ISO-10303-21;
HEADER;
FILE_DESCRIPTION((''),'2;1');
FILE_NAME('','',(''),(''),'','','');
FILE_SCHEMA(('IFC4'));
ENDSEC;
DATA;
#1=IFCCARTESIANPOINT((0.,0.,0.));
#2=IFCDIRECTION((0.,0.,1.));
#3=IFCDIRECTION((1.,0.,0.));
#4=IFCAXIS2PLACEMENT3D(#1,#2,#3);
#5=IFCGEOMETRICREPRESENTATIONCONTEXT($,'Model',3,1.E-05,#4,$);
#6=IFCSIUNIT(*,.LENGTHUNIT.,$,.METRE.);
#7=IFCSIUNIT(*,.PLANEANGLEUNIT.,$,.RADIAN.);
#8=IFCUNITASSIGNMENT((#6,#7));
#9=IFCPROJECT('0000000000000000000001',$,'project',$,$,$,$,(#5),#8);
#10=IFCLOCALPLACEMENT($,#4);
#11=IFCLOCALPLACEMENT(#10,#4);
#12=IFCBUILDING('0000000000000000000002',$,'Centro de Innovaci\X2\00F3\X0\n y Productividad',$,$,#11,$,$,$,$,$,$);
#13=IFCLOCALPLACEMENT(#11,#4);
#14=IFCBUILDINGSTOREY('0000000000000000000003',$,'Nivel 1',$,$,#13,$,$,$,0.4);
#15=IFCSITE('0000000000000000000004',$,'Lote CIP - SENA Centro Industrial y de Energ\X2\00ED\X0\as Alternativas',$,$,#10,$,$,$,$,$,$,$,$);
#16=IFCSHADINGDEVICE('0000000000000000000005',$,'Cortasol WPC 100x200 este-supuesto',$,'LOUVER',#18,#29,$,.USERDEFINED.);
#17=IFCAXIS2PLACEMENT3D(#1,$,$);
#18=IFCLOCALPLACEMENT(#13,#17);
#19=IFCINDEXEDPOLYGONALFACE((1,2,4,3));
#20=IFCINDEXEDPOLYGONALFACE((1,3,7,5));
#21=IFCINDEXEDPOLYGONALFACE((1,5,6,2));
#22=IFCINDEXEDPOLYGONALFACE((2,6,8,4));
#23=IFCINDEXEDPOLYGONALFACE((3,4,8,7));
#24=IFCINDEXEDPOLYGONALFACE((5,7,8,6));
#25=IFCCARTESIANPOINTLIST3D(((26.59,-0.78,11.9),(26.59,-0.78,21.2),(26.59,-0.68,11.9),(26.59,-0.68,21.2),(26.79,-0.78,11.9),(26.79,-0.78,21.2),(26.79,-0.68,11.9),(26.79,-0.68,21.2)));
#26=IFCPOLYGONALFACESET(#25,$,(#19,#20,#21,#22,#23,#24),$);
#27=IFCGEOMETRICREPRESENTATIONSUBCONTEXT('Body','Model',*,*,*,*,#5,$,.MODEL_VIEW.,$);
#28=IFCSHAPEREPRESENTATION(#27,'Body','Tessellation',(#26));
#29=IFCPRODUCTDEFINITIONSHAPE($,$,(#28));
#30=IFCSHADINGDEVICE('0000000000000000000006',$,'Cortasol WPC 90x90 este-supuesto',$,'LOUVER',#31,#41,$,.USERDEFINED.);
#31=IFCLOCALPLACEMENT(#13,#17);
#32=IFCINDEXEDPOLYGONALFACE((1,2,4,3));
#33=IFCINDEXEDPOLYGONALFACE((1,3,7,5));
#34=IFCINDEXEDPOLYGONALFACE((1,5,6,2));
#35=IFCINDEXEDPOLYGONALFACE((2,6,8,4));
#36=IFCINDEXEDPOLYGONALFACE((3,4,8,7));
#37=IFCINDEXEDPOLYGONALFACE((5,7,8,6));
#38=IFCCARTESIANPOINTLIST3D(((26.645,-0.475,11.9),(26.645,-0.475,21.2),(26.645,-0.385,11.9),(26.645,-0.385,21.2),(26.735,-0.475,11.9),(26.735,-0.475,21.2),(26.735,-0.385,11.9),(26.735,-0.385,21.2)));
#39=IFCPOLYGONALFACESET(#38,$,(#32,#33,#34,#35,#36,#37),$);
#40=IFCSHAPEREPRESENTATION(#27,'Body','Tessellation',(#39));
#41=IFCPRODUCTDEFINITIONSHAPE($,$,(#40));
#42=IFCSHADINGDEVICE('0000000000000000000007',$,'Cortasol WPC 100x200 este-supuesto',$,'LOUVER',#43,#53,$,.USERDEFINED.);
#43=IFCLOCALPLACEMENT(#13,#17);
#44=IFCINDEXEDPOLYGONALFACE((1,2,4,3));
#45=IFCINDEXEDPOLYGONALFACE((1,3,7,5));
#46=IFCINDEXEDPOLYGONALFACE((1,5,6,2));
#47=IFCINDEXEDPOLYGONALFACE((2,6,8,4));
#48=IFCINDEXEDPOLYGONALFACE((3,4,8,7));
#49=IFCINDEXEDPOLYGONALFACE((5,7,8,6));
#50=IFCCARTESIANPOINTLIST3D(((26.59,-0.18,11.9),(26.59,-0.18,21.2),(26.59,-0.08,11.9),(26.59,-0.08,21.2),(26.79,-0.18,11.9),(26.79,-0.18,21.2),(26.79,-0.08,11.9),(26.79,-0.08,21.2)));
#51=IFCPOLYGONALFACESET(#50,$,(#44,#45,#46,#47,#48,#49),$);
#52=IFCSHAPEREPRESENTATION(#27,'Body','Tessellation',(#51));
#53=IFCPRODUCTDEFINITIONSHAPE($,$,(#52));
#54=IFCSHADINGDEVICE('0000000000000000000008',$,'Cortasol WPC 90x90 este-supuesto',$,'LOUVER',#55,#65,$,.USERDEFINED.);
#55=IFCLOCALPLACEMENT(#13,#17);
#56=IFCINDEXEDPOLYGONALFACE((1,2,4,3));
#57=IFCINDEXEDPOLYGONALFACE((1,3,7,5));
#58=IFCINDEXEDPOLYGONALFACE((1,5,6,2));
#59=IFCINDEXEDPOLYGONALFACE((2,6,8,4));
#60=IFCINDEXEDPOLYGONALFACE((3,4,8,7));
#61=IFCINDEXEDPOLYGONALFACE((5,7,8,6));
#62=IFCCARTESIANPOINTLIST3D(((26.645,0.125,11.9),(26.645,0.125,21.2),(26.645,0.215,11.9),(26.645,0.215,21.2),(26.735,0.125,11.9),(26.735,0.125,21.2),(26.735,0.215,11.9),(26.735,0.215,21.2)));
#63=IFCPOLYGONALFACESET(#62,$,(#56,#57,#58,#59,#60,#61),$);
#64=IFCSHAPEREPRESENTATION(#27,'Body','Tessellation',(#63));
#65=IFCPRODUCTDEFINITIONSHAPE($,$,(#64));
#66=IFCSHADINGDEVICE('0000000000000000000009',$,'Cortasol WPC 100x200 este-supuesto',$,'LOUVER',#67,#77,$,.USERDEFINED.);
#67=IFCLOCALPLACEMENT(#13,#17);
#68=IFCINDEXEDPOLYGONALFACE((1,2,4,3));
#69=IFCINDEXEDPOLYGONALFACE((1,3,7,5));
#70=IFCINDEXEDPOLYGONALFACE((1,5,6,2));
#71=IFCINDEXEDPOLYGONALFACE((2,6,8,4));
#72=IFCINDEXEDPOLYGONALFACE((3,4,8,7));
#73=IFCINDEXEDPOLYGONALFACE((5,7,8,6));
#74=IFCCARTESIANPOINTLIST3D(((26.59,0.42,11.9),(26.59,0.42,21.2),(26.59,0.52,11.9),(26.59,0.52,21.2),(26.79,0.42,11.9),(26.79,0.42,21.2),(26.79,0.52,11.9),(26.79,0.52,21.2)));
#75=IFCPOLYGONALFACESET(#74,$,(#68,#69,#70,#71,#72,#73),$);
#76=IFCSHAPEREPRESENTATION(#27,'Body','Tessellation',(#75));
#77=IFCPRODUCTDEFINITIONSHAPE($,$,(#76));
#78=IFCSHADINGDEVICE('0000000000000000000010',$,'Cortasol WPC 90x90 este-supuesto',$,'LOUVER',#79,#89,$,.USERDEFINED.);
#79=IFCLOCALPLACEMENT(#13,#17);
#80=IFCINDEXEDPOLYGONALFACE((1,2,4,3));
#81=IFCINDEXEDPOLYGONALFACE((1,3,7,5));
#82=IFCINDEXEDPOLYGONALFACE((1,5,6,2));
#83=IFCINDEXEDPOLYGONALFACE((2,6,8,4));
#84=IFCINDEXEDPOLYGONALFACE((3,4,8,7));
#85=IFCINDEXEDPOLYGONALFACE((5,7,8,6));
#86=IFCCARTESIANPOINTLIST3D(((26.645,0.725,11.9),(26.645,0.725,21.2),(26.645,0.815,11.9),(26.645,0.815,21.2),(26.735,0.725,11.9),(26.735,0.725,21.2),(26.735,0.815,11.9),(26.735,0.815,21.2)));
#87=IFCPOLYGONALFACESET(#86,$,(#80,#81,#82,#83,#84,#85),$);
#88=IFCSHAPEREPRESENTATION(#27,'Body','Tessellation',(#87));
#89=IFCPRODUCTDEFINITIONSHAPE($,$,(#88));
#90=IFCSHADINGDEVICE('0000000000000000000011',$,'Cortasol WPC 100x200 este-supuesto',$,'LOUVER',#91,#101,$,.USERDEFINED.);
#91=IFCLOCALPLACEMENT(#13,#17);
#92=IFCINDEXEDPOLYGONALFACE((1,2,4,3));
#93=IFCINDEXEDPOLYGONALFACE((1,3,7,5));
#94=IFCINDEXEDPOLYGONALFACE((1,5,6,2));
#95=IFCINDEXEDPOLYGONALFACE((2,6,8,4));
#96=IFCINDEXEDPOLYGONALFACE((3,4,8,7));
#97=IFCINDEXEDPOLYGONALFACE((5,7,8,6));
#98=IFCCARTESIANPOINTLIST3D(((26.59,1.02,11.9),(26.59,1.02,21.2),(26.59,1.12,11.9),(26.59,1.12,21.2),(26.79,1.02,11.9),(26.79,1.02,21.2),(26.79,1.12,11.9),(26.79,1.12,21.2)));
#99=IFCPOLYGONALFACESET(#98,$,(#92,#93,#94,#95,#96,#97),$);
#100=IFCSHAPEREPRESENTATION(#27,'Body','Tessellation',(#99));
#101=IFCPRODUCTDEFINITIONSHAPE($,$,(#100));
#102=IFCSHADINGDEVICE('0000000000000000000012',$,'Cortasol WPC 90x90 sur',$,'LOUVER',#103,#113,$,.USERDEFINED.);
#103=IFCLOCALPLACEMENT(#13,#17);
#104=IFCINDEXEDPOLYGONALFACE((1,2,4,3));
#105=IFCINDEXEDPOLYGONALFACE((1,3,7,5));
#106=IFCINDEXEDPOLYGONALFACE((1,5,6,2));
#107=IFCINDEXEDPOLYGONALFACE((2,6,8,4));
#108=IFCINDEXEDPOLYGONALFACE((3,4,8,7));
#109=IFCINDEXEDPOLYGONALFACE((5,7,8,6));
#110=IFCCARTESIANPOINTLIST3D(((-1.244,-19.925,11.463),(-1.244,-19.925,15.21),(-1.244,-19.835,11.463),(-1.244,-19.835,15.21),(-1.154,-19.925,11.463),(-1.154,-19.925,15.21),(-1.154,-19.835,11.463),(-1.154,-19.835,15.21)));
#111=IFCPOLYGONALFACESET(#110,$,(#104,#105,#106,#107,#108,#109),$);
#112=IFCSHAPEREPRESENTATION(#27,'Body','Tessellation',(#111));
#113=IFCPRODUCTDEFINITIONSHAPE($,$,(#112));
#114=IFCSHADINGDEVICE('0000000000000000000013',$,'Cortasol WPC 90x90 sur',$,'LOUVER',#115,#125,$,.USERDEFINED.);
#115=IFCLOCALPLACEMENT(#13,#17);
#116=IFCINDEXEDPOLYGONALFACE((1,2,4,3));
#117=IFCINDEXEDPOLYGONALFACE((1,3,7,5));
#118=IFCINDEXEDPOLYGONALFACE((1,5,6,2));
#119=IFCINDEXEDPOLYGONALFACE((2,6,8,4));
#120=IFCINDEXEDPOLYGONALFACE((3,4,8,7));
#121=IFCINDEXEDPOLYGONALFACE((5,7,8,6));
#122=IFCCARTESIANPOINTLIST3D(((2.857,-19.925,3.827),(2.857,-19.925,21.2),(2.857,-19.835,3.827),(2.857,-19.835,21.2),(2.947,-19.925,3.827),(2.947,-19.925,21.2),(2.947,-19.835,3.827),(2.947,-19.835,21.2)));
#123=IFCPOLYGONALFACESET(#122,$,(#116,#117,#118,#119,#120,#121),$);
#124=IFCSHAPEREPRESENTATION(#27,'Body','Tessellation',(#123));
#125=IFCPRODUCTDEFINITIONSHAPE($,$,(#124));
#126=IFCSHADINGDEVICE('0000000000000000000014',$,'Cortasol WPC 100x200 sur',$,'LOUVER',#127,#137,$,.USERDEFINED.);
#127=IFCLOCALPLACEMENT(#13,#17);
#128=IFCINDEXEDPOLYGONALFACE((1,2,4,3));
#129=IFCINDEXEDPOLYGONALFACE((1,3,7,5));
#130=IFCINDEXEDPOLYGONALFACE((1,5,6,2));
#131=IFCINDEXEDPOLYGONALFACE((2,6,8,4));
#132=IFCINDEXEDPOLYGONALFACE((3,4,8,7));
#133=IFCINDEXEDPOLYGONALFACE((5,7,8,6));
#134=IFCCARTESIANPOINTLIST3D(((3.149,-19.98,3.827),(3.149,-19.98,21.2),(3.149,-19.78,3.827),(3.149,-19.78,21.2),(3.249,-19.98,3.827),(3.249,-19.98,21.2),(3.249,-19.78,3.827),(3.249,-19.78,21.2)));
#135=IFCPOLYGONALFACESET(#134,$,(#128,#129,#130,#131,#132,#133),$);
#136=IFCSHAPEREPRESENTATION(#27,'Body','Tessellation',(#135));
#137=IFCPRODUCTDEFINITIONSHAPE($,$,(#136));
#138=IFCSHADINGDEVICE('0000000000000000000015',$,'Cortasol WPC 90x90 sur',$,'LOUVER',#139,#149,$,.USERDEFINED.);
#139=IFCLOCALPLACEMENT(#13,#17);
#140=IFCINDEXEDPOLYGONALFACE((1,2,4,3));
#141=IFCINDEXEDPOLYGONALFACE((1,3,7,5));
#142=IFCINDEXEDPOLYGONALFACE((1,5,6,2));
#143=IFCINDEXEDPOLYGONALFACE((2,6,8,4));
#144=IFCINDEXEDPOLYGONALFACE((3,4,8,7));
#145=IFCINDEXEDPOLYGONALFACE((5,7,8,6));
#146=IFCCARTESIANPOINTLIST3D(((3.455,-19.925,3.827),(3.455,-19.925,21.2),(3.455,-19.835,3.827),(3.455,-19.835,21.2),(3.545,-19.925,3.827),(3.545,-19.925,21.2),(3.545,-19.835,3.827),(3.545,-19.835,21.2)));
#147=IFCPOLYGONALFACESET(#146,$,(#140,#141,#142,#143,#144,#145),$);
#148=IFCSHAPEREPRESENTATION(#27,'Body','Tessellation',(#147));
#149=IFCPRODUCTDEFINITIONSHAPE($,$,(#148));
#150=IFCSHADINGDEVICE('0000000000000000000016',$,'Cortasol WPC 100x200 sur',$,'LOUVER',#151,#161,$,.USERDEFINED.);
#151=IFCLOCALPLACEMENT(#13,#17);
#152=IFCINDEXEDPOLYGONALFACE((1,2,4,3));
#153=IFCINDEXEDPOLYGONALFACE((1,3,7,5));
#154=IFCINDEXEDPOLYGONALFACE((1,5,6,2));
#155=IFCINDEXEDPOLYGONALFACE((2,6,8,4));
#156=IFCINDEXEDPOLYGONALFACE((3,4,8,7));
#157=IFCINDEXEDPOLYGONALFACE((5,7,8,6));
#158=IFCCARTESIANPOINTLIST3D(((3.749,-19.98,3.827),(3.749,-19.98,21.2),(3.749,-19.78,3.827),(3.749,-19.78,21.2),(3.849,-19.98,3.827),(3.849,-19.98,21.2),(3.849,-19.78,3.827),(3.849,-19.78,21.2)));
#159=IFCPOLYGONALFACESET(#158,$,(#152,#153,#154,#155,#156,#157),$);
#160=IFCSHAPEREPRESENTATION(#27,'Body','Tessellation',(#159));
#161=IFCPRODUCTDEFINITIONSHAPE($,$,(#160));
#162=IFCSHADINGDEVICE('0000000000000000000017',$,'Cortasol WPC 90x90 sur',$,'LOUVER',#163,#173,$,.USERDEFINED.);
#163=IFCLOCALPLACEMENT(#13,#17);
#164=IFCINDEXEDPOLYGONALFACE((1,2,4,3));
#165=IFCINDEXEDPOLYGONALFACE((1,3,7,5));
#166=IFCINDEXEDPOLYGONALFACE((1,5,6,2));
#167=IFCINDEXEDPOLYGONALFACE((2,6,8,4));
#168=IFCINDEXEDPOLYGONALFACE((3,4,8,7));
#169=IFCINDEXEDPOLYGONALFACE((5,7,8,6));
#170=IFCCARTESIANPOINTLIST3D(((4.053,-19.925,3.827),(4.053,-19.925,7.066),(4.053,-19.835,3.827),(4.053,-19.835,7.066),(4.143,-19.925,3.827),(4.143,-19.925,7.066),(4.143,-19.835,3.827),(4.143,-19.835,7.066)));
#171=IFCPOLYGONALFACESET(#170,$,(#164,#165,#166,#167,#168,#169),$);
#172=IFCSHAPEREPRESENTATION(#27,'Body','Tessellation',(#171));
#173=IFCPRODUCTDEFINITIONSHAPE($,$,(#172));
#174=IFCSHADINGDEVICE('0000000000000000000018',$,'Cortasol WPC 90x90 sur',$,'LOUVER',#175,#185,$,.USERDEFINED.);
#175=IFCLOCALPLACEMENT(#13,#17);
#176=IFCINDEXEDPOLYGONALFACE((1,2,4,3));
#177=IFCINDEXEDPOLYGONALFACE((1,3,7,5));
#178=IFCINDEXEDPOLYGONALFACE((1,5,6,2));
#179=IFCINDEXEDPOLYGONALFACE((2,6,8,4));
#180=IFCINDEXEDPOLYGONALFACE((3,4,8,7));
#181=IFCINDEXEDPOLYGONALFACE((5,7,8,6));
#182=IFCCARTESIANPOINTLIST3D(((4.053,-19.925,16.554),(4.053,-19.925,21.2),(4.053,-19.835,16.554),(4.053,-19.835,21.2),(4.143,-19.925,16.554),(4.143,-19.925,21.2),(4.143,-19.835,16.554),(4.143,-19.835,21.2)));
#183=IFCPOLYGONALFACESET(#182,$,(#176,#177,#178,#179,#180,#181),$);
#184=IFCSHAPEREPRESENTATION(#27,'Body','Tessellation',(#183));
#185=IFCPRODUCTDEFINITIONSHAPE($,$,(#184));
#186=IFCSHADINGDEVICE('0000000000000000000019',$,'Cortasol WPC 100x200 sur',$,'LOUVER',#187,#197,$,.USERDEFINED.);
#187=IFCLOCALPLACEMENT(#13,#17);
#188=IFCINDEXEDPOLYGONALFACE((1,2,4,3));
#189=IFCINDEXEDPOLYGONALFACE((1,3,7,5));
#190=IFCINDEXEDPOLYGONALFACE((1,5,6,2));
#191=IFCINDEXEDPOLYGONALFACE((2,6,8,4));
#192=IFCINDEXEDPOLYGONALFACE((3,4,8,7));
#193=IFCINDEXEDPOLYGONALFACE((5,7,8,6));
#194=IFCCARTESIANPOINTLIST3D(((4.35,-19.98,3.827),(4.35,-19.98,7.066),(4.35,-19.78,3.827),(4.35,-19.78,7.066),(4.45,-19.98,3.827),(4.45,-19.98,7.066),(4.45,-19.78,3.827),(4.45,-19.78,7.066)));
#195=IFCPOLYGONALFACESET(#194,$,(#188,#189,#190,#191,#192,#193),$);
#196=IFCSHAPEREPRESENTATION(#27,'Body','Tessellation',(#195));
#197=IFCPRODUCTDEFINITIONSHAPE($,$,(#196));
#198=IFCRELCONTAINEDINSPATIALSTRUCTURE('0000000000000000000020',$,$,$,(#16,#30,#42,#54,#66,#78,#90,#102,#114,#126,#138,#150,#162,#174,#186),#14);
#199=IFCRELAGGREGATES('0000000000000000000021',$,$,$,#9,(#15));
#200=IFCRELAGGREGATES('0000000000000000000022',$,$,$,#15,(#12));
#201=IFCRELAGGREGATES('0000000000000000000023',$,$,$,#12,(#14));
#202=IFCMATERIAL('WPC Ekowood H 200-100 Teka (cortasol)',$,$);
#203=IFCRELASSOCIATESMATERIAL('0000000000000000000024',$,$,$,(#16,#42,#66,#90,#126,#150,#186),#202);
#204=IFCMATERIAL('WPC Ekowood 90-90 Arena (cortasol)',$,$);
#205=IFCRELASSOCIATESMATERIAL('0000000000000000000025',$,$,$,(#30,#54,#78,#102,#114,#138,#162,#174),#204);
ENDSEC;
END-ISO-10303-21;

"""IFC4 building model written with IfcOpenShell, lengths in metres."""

from ifc_helpers import new_model, si_unit, frame, origin_with_axes, place, context, subcontext, project, spatial, polyline, outline, extrude, material, element, save


model = new_model("IFC4")

# Units and contexts
model_context = context("Model", 3, precision=1e-05, world=origin_with_axes())
body_context = subcontext(model_context, "Body", "Model", "MODEL_VIEW")
ifc_project = project(units=[si_unit("LENGTHUNIT", "METRE"), si_unit("PLANEANGLEUNIT", "RADIAN")], contexts=[model_context])

# Site, building, storey
site_placement = place(None, origin_with_axes())
site = spatial("IfcSite", under=ifc_project, at=site_placement, Name="Lote CIP - SENA Centro Industrial y de Energías Alternativas")
building_placement = place(site_placement, origin_with_axes())
building = spatial("IfcBuilding", under=site, at=building_placement, Name="Centro de Innovación y Productividad")
storey_placement = place(building_placement, origin_with_axes())
storey = spatial("IfcBuildingStorey", under=building, at=storey_placement, Name="Nivel 1", Elevation=0.4)

# Shading devices
ifc_material_1 = material(Name="WPC Ekowood H 200-100 Teka (cortasol)")
shading_device_1_placement = place(storey_placement, origin_with_axes())
element("IfcShadingDevice", 1, at=shading_device_1_placement, inside=storey, material=ifc_material_1, Name="Cortasol WPC 100x200 este-supuesto", ObjectType="LOUVER", PredefinedType="USERDEFINED", context=body_context, shape_type="SweptSolid", body=[
    extrude(outline(polyline([(26.79, -0.78), (26.59, -0.78), (26.59, -0.68), (26.79, -0.68), (26.79, -0.78)])), frame((0.0, 0.0, 11.9)), (0.0, 0.0, 1.0), 9.3),
])
ifc_material_2 = material(Name="WPC Ekowood 90-90 Arena (cortasol)")
shading_device_2_placement = place(storey_placement, origin_with_axes())
element("IfcShadingDevice", 2, at=shading_device_2_placement, inside=storey, material=ifc_material_2, Name="Cortasol WPC 90x90 este-supuesto", ObjectType="LOUVER", PredefinedType="USERDEFINED", context=body_context, shape_type="SweptSolid", body=[
    extrude(outline(polyline([(26.735, -0.475), (26.645, -0.475), (26.645, -0.385), (26.735, -0.385), (26.735, -0.475)])), frame((0.0, 0.0, 11.9)), (0.0, 0.0, 1.0), 9.3),
])
shading_device_3_placement = place(storey_placement, origin_with_axes())
element("IfcShadingDevice", 3, at=shading_device_3_placement, inside=storey, material=ifc_material_1, Name="Cortasol WPC 100x200 este-supuesto", ObjectType="LOUVER", PredefinedType="USERDEFINED", context=body_context, shape_type="SweptSolid", body=[
    extrude(outline(polyline([(26.79, -0.18), (26.59, -0.18), (26.59, -0.08), (26.79, -0.08), (26.79, -0.18)])), frame((0.0, 0.0, 11.9)), (0.0, 0.0, 1.0), 9.3),
])
shading_device_4_placement = place(storey_placement, origin_with_axes())
element("IfcShadingDevice", 4, at=shading_device_4_placement, inside=storey, material=ifc_material_2, Name="Cortasol WPC 90x90 este-supuesto", ObjectType="LOUVER", PredefinedType="USERDEFINED", context=body_context, shape_type="SweptSolid", body=[
    extrude(outline(polyline([(26.735, 0.125), (26.645, 0.125), (26.645, 0.215), (26.735, 0.215), (26.735, 0.125)])), frame((0.0, 0.0, 11.9)), (0.0, 0.0, 1.0), 9.3),
])
shading_device_5_placement = place(storey_placement, origin_with_axes())
element("IfcShadingDevice", 5, at=shading_device_5_placement, inside=storey, material=ifc_material_1, Name="Cortasol WPC 100x200 este-supuesto", ObjectType="LOUVER", PredefinedType="USERDEFINED", context=body_context, shape_type="SweptSolid", body=[
    extrude(outline(polyline([(26.79, 0.42), (26.59, 0.42), (26.59, 0.52), (26.79, 0.52), (26.79, 0.42)])), frame((0.0, 0.0, 11.9)), (0.0, 0.0, 1.0), 9.3),
])
shading_device_6_placement = place(storey_placement, origin_with_axes())
element("IfcShadingDevice", 6, at=shading_device_6_placement, inside=storey, material=ifc_material_2, Name="Cortasol WPC 90x90 este-supuesto", ObjectType="LOUVER", PredefinedType="USERDEFINED", context=body_context, shape_type="SweptSolid", body=[
    extrude(outline(polyline([(26.735, 0.725), (26.645, 0.725), (26.645, 0.815), (26.735, 0.815), (26.735, 0.725)])), frame((0.0, 0.0, 11.9)), (0.0, 0.0, 1.0), 9.3),
])
shading_device_7_placement = place(storey_placement, origin_with_axes())
element("IfcShadingDevice", 7, at=shading_device_7_placement, inside=storey, material=ifc_material_1, Name="Cortasol WPC 100x200 este-supuesto", ObjectType="LOUVER", PredefinedType="USERDEFINED", context=body_context, shape_type="SweptSolid", body=[
    extrude(outline(polyline([(26.79, 1.02), (26.59, 1.02), (26.59, 1.12), (26.79, 1.12), (26.79, 1.02)])), frame((0.0, 0.0, 11.9)), (0.0, 0.0, 1.0), 9.3),
])
shading_device_8_placement = place(storey_placement, origin_with_axes())
element("IfcShadingDevice", 8, at=shading_device_8_placement, inside=storey, material=ifc_material_2, Name="Cortasol WPC 90x90 sur", ObjectType="LOUVER", PredefinedType="USERDEFINED", context=body_context, shape_type="SweptSolid", body=[
    extrude(outline(polyline([(-1.244, -19.925), (-1.244, -19.835), (-1.154, -19.835), (-1.154, -19.925), (-1.244, -19.925)])), frame((0.0, 0.0, 11.463)), (0.0, 0.0, 1.0), 3.747),
])
shading_device_9_placement = place(storey_placement, origin_with_axes())
element("IfcShadingDevice", 9, at=shading_device_9_placement, inside=storey, material=ifc_material_2, Name="Cortasol WPC 90x90 sur", ObjectType="LOUVER", PredefinedType="USERDEFINED", context=body_context, shape_type="SweptSolid", body=[
    extrude(outline(polyline([(2.857, -19.925), (2.857, -19.835), (2.947, -19.835), (2.947, -19.925), (2.857, -19.925)])), frame((0.0, 0.0, 3.827)), (0.0, 0.0, 1.0), 17.373),
])
shading_device_10_placement = place(storey_placement, origin_with_axes())
element("IfcShadingDevice", 10, at=shading_device_10_placement, inside=storey, material=ifc_material_1, Name="Cortasol WPC 100x200 sur", ObjectType="LOUVER", PredefinedType="USERDEFINED", context=body_context, shape_type="SweptSolid", body=[
    extrude(outline(polyline([(3.149, -19.98), (3.149, -19.78), (3.249, -19.78), (3.249, -19.98), (3.149, -19.98)])), frame((0.0, 0.0, 3.827)), (0.0, 0.0, 1.0), 17.373),
])
shading_device_11_placement = place(storey_placement, origin_with_axes())
element("IfcShadingDevice", 11, at=shading_device_11_placement, inside=storey, material=ifc_material_2, Name="Cortasol WPC 90x90 sur", ObjectType="LOUVER", PredefinedType="USERDEFINED", context=body_context, shape_type="SweptSolid", body=[
    extrude(outline(polyline([(3.455, -19.925), (3.455, -19.835), (3.545, -19.835), (3.545, -19.925), (3.455, -19.925)])), frame((0.0, 0.0, 3.827)), (0.0, 0.0, 1.0), 17.373),
])
shading_device_12_placement = place(storey_placement, origin_with_axes())
element("IfcShadingDevice", 12, at=shading_device_12_placement, inside=storey, material=ifc_material_1, Name="Cortasol WPC 100x200 sur", ObjectType="LOUVER", PredefinedType="USERDEFINED", context=body_context, shape_type="SweptSolid", body=[
    extrude(outline(polyline([(3.749, -19.98), (3.749, -19.78), (3.849, -19.78), (3.849, -19.98), (3.749, -19.98)])), frame((0.0, 0.0, 3.827)), (0.0, 0.0, 1.0), 17.373),
])
shading_device_13_placement = place(storey_placement, origin_with_axes())
element("IfcShadingDevice", 13, at=shading_device_13_placement, inside=storey, material=ifc_material_2, Name="Cortasol WPC 90x90 sur", ObjectType="LOUVER", PredefinedType="USERDEFINED", context=body_context, shape_type="SweptSolid", body=[
    extrude(outline(polyline([(4.053, -19.925), (4.053, -19.835), (4.143, -19.835), (4.143, -19.925), (4.053, -19.925)])), frame((0.0, 0.0, 3.827)), (0.0, 0.0, 1.0), 3.239),
])
shading_device_14_placement = place(storey_placement, origin_with_axes())
element("IfcShadingDevice", 14, at=shading_device_14_placement, inside=storey, material=ifc_material_2, Name="Cortasol WPC 90x90 sur", ObjectType="LOUVER", PredefinedType="USERDEFINED", context=body_context, shape_type="SweptSolid", body=[
    extrude(outline(polyline([(4.053, -19.925), (4.053, -19.835), (4.143, -19.835), (4.143, -19.925), (4.053, -19.925)])), frame((0.0, 0.0, 16.554)), (0.0, 0.0, 1.0), 4.646),
])
shading_device_15_placement = place(storey_placement, origin_with_axes())
element("IfcShadingDevice", 15, at=shading_device_15_placement, inside=storey, material=ifc_material_1, Name="Cortasol WPC 100x200 sur", ObjectType="LOUVER", PredefinedType="USERDEFINED", context=body_context, shape_type="SweptSolid", body=[
    extrude(outline(polyline([(4.35, -19.98), (4.35, -19.78), (4.45, -19.78), (4.45, -19.98), (4.35, -19.98)])), frame((0.0, 0.0, 3.827)), (0.0, 0.0, 1.0), 3.239),
])

save(model, "model.ifc")
